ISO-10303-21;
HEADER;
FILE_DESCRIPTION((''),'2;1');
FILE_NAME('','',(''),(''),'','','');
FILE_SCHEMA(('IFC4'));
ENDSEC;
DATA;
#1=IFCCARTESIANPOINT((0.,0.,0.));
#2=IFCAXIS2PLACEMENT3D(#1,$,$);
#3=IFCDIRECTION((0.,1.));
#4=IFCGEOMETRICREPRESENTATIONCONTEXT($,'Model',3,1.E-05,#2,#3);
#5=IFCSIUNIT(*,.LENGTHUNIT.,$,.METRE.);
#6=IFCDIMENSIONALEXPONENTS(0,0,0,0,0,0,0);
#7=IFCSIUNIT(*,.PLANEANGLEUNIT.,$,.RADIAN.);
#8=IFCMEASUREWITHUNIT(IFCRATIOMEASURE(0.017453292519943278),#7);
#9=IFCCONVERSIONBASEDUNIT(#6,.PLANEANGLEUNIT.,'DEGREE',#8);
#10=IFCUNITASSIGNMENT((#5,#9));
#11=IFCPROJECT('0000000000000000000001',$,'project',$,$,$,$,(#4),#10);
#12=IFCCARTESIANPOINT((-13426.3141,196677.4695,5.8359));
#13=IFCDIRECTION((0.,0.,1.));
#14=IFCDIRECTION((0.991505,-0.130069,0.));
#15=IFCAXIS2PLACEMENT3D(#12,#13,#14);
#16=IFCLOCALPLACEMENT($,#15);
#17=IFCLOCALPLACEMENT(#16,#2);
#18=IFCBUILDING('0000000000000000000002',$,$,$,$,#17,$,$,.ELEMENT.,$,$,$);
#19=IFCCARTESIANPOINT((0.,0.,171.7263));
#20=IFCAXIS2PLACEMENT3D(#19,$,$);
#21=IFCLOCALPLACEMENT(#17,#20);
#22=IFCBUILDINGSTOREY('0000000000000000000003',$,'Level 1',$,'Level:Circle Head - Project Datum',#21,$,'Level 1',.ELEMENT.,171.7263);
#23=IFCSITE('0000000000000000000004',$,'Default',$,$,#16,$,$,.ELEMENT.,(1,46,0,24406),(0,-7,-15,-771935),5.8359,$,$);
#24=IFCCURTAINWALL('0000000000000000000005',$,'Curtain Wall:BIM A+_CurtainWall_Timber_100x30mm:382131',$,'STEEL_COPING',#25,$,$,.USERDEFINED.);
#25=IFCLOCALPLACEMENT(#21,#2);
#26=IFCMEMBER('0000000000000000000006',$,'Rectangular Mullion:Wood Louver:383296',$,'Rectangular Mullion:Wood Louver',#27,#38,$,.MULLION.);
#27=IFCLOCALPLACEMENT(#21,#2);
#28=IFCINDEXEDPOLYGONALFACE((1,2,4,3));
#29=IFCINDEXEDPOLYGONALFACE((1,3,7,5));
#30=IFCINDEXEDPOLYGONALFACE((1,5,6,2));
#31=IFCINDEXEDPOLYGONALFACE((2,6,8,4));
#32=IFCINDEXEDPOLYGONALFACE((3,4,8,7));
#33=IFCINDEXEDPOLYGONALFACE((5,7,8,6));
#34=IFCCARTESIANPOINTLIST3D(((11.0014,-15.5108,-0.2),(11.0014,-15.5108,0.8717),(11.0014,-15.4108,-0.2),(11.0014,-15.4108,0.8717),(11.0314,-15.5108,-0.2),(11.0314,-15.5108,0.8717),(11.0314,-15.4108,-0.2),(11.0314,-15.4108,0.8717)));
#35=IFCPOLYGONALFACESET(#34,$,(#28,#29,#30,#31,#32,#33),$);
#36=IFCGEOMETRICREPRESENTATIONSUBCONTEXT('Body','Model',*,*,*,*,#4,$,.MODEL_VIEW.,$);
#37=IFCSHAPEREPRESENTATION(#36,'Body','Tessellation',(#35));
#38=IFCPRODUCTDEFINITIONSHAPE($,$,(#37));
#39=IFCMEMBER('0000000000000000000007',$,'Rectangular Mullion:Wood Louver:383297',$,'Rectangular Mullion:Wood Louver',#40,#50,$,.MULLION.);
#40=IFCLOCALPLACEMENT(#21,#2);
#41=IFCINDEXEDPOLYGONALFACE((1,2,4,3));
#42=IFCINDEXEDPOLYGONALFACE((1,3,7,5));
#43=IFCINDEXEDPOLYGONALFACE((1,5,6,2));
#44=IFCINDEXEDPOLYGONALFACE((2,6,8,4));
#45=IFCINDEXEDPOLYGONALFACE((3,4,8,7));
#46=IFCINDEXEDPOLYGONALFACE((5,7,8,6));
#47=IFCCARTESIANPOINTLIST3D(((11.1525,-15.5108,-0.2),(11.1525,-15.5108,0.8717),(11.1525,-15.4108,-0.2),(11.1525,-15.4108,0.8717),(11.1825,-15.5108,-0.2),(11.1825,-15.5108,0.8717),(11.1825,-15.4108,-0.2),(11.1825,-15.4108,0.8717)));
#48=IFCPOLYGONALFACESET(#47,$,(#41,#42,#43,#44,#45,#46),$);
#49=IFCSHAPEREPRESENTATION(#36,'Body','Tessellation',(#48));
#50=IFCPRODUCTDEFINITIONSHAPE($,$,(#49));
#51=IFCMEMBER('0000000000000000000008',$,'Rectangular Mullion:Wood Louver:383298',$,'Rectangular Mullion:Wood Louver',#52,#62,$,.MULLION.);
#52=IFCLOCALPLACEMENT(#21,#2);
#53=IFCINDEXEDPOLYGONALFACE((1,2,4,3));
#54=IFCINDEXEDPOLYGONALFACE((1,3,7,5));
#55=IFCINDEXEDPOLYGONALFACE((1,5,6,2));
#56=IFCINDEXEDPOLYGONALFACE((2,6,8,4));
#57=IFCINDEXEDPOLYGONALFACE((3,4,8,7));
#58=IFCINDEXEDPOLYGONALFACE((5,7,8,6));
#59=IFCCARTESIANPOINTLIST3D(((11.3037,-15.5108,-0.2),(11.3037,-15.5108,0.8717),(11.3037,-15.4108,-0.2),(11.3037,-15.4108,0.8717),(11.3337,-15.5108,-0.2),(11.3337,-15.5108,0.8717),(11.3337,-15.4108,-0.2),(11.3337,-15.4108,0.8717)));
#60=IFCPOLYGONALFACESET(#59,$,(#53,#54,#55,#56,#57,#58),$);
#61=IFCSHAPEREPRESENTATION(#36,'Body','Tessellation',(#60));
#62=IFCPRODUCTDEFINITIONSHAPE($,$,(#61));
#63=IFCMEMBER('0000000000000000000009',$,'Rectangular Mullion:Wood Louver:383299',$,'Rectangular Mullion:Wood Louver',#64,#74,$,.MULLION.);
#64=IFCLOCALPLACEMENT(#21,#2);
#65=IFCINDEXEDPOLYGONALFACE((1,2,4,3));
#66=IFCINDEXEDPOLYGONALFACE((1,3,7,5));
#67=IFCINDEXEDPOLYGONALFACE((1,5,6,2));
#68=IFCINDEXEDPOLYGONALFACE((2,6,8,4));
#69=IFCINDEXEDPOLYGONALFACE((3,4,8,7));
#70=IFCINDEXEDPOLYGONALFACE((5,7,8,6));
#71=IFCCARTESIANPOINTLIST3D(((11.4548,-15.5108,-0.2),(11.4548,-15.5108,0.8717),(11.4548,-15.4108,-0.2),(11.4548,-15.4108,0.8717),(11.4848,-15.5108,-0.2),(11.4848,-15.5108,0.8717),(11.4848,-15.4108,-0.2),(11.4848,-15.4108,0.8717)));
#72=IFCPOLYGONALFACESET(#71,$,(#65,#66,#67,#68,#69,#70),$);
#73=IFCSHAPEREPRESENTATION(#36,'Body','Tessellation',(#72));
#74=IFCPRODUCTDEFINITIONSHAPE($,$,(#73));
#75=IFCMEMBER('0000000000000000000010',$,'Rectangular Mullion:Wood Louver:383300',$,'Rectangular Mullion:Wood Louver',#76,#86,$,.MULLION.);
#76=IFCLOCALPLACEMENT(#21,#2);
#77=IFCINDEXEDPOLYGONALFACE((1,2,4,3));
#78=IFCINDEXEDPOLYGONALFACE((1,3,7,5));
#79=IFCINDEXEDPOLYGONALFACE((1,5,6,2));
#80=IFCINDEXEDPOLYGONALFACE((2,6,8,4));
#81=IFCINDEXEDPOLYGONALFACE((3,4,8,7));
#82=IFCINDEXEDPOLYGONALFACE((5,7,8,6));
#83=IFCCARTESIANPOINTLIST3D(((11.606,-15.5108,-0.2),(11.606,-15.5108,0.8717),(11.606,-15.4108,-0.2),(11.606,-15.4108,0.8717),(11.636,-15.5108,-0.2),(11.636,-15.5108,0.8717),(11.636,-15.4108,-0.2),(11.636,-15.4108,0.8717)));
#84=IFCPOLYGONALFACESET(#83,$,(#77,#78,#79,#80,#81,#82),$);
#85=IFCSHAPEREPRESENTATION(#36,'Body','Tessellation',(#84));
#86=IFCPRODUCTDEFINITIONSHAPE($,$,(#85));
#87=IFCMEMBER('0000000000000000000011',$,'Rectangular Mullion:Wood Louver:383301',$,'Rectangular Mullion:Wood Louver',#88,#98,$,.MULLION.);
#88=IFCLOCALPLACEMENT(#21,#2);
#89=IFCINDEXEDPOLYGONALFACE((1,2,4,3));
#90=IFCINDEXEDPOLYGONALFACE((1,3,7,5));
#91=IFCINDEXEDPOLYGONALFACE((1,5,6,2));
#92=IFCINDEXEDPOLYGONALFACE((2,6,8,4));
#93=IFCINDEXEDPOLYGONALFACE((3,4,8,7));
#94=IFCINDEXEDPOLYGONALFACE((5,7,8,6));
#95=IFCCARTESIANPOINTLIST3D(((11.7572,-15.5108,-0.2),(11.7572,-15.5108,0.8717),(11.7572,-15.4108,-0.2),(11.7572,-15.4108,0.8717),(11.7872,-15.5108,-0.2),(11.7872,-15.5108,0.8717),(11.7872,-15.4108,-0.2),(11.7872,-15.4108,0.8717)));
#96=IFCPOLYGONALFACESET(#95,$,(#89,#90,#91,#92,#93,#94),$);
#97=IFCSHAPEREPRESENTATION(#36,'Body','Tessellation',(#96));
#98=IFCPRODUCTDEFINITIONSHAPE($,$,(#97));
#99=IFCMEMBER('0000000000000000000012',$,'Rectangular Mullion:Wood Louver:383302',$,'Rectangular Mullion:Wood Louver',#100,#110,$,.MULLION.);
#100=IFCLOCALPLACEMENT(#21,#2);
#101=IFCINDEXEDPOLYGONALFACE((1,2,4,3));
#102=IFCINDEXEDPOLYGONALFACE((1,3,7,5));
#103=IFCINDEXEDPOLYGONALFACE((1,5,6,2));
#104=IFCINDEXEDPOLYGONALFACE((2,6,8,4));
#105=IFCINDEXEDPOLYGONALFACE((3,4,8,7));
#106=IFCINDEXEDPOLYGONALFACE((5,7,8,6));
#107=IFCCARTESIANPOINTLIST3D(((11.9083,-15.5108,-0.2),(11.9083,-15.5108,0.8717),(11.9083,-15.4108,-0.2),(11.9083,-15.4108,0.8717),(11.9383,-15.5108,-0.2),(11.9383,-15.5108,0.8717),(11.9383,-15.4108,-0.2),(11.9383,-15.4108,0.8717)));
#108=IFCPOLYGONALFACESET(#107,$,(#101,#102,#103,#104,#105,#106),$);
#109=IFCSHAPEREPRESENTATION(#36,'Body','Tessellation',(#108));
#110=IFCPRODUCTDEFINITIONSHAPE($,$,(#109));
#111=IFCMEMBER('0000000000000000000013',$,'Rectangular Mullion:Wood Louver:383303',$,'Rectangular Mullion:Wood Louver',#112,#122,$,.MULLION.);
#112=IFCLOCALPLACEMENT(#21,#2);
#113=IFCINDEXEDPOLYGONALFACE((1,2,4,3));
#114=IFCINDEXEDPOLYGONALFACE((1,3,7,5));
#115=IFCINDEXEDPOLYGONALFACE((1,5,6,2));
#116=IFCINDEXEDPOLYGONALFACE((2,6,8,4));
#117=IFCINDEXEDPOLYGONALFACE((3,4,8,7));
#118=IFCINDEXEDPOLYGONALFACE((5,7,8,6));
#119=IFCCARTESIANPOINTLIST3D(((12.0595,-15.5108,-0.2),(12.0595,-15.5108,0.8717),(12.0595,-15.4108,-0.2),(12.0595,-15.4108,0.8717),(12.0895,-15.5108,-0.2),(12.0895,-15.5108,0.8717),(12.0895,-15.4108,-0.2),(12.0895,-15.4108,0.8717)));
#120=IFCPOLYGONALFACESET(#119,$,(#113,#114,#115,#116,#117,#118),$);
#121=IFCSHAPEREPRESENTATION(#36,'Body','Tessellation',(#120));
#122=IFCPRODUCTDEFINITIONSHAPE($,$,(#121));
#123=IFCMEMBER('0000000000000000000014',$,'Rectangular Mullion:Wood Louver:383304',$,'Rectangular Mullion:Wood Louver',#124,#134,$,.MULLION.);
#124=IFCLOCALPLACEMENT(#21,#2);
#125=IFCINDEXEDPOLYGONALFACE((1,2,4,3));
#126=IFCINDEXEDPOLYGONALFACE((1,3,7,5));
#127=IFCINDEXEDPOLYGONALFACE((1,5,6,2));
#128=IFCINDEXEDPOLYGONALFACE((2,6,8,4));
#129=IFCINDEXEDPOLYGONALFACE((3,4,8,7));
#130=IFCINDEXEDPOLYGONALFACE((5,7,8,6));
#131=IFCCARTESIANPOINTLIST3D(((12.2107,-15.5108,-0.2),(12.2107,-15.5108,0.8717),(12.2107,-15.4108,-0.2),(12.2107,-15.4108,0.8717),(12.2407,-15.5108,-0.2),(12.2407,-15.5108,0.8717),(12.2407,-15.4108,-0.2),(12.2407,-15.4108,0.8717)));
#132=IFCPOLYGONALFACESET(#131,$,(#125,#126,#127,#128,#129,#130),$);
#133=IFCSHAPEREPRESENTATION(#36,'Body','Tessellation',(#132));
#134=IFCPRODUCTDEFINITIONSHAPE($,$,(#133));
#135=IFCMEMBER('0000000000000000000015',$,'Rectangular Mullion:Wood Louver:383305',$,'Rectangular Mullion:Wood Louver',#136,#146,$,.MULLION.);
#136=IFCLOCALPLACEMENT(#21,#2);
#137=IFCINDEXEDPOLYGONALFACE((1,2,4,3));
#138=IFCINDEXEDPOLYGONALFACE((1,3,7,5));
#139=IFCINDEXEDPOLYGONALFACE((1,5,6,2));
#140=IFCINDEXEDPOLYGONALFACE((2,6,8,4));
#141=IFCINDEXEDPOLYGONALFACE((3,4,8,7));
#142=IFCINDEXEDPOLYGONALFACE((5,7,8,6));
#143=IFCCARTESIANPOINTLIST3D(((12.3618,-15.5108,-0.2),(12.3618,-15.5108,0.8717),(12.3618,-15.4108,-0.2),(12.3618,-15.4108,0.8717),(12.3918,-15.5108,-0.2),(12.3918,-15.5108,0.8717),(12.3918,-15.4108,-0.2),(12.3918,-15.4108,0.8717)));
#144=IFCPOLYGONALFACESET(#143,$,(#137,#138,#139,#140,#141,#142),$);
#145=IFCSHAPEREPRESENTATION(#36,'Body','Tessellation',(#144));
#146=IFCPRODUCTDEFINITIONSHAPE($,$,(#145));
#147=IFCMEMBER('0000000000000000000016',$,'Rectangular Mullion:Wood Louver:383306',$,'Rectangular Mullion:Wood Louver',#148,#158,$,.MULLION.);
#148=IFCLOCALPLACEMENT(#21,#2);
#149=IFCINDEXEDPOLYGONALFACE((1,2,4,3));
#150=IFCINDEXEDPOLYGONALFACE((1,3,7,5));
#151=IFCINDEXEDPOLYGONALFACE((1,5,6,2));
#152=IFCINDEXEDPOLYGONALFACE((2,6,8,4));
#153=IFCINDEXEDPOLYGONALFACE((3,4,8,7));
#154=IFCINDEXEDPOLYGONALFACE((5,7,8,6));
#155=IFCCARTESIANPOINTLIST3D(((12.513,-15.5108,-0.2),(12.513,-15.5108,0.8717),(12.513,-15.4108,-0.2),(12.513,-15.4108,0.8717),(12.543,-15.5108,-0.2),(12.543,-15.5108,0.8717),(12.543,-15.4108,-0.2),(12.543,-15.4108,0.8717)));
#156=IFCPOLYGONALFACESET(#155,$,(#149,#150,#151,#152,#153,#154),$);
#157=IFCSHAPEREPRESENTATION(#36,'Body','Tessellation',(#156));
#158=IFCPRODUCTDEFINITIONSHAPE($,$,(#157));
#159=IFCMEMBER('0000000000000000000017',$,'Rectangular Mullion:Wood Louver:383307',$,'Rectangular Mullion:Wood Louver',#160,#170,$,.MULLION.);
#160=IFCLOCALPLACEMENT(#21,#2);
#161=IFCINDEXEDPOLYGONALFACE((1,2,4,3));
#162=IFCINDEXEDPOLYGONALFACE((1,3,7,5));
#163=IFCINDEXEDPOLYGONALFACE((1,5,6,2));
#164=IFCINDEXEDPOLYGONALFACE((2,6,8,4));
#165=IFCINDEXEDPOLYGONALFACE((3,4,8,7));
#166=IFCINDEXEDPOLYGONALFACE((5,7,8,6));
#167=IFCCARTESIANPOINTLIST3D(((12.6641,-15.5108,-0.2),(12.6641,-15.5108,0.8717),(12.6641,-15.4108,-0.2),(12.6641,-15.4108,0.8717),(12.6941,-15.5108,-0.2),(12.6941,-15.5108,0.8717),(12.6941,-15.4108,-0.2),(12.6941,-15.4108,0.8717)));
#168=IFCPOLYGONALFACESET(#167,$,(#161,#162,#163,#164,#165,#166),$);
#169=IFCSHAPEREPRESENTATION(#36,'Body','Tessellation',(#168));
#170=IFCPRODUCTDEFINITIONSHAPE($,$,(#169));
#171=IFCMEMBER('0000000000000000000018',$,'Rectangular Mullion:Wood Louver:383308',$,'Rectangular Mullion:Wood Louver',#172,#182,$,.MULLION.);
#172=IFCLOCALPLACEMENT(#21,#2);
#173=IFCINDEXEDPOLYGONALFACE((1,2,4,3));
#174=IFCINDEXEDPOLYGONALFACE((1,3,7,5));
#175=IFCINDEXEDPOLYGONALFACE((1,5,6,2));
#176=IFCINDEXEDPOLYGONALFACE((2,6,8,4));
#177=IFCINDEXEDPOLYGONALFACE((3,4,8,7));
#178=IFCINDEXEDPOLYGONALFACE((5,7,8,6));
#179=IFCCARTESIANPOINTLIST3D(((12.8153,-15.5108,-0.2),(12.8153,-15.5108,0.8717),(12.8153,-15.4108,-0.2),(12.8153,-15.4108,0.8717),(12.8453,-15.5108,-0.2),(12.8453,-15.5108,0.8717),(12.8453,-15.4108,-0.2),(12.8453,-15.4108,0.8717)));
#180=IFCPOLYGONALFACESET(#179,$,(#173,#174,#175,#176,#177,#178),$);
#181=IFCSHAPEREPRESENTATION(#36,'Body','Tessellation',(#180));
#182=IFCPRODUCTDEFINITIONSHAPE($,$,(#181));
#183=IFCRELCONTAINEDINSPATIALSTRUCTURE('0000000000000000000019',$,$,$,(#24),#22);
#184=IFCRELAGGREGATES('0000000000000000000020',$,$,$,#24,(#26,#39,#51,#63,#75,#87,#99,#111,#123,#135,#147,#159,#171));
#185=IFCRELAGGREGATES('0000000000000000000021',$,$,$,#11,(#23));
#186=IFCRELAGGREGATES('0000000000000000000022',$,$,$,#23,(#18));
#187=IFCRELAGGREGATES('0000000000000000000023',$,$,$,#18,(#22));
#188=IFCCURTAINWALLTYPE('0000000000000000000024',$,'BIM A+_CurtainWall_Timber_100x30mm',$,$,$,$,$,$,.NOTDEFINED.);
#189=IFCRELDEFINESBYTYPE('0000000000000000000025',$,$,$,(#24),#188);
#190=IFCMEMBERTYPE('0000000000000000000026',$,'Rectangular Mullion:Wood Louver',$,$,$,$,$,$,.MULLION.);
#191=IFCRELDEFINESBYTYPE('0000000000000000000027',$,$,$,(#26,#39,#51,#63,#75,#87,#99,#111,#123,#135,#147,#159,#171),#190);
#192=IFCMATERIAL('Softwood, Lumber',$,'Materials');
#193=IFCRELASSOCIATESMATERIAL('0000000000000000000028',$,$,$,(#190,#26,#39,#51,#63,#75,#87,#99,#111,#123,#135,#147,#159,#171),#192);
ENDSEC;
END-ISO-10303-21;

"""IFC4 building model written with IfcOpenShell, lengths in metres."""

from ifc_helpers import new_model, entity, si_unit, converted_unit, direction, frame, origin, place, context, subcontext, project, spatial, indexed_curve, outline, extrude, source, transform, mapped, material, type_object, type_shapes, element, aggregate, save


model = new_model("IFC4")

# Units and contexts
model_context = context("Model", 3, precision=1e-05, world=origin(), true_north=direction((0.0, 1.0)))
body_context = subcontext(model_context, "Body", "Model", "MODEL_VIEW")
ifc_project = project(units=[si_unit("LENGTHUNIT", "METRE"), converted_unit("PLANEANGLEUNIT", "DEGREE", entity("IfcRatioMeasure", 0.017453292519943278), si_unit("PLANEANGLEUNIT", "RADIAN"), dimensions=[0, 0, 0, 0, 0, 0, 0])], contexts=[model_context])

# Site, building, storey
site_placement = place(None, frame((-13426.3141, 196677.4695, 5.8359), z_axis=(0.0, 0.0, 1.0), x_axis=(0.991505, -0.130069, 0.0)))
site = spatial("IfcSite", under=ifc_project, at=site_placement, Name="Default", CompositionType="ELEMENT", RefLatitude=(1, 46, 0, 24406), RefLongitude=(0, -7, -15, -771935), RefElevation=5.8359)
building_placement = place(site_placement, origin())
building = spatial("IfcBuilding", under=site, at=building_placement, CompositionType="ELEMENT")
storey_placement = place(building_placement, frame((0.0, 0.0, 171.7263)))
storey = spatial("IfcBuildingStorey", under=building, at=storey_placement, Name="Level 1", ObjectType="Level:Circle Head - Project Datum", LongName="Level 1", CompositionType="ELEMENT", Elevation=171.7263)

# Curtain wall, members
curtain_wall_type = type_object("IfcCurtainWallType", Name="BIM A+_CurtainWall_Timber_100x30mm", PredefinedType="NOTDEFINED")
curtain_wall_placement = place(storey_placement, frame((0.0, 0.0, -171.7263)))
curtain_wall = element("IfcCurtainWall", 1, at=curtain_wall_placement, inside=storey, type_object=curtain_wall_type, Name="Curtain Wall:BIM A+_CurtainWall_Timber_100x30mm:382131", ObjectType="STEEL_COPING", PredefinedType="USERDEFINED")
ifc_material_1 = material(Name="Softwood, Lumber", Category="Materials")
member_type_1 = type_object("IfcMemberType", Name="Rectangular Mullion:Wood Louver", PredefinedType="MULLION", material=ifc_material_1)
shared_shape_1 = source(origin(), body_context, "Body", "SweptSolid", [
    extrude(outline(indexed_curve([(-0.05, -0.015), (0.05, -0.015), (0.05, 0.015), (-0.05, 0.015), (-0.05, -0.015)], self_intersect=False)), frame((0.0, -0.035, -1.0717), z_axis=(0.0, 0.0, 1.0), x_axis=(0.0, -1.0, 0.0)), (0.0, 0.0, 1.0), 1.0717),
])
type_shapes(member_type_1, [shared_shape_1])
member_1_placement = place(curtain_wall_placement, frame((11.0164, -15.4958, 171.5263), z_axis=(0.0, 0.0, -1.0), x_axis=(1.0, 0.0, 0.0)))
member_1 = element("IfcMember", 2, at=member_1_placement, type_object=member_type_1, material=ifc_material_1, Name="Rectangular Mullion:Wood Louver:383296", ObjectType="Rectangular Mullion:Wood Louver", PredefinedType="MULLION", context=body_context, shape_type="MappedRepresentation", body=[
    mapped(shared_shape_1, transform((0.0, 0.0, 0.0), scale=1.0)),
])
member_2_placement = place(curtain_wall_placement, frame((11.1675, -15.4958, 171.5263), z_axis=(0.0, 0.0, -1.0), x_axis=(1.0, 0.0, 0.0)))
member_2 = element("IfcMember", 3, at=member_2_placement, type_object=member_type_1, material=ifc_material_1, Name="Rectangular Mullion:Wood Louver:383297", ObjectType="Rectangular Mullion:Wood Louver", PredefinedType="MULLION", context=body_context, shape_type="MappedRepresentation", body=[
    mapped(shared_shape_1, transform((0.0, 0.0, 0.0), scale=1.0)),
])
member_3_placement = place(curtain_wall_placement, frame((11.3187, -15.4958, 171.5263), z_axis=(0.0, 0.0, -1.0), x_axis=(1.0, 0.0, 0.0)))
member_3 = element("IfcMember", 4, at=member_3_placement, type_object=member_type_1, material=ifc_material_1, Name="Rectangular Mullion:Wood Louver:383298", ObjectType="Rectangular Mullion:Wood Louver", PredefinedType="MULLION", context=body_context, shape_type="MappedRepresentation", body=[
    mapped(shared_shape_1, transform((0.0, 0.0, 0.0), scale=1.0)),
])
member_4_placement = place(curtain_wall_placement, frame((11.4698, -15.4958, 171.5263), z_axis=(0.0, 0.0, -1.0), x_axis=(1.0, 0.0, 0.0)))
member_4 = element("IfcMember", 5, at=member_4_placement, type_object=member_type_1, material=ifc_material_1, Name="Rectangular Mullion:Wood Louver:383299", ObjectType="Rectangular Mullion:Wood Louver", PredefinedType="MULLION", context=body_context, shape_type="MappedRepresentation", body=[
    mapped(shared_shape_1, transform((0.0, 0.0, 0.0), scale=1.0)),
])
member_5_placement = place(curtain_wall_placement, frame((11.621, -15.4958, 171.5263), z_axis=(0.0, 0.0, -1.0), x_axis=(1.0, 0.0, 0.0)))
member_5 = element("IfcMember", 6, at=member_5_placement, type_object=member_type_1, material=ifc_material_1, Name="Rectangular Mullion:Wood Louver:383300", ObjectType="Rectangular Mullion:Wood Louver", PredefinedType="MULLION", context=body_context, shape_type="MappedRepresentation", body=[
    mapped(shared_shape_1, transform((0.0, 0.0, 0.0), scale=1.0)),
])
member_6_placement = place(curtain_wall_placement, frame((11.7722, -15.4958, 171.5263), z_axis=(0.0, 0.0, -1.0), x_axis=(1.0, 0.0, 0.0)))
member_6 = element("IfcMember", 7, at=member_6_placement, type_object=member_type_1, material=ifc_material_1, Name="Rectangular Mullion:Wood Louver:383301", ObjectType="Rectangular Mullion:Wood Louver", PredefinedType="MULLION", context=body_context, shape_type="MappedRepresentation", body=[
    mapped(shared_shape_1, transform((0.0, 0.0, 0.0), scale=1.0)),
])
member_7_placement = place(curtain_wall_placement, frame((11.9233, -15.4958, 171.5263), z_axis=(0.0, 0.0, -1.0), x_axis=(1.0, 0.0, 0.0)))
member_7 = element("IfcMember", 8, at=member_7_placement, type_object=member_type_1, material=ifc_material_1, Name="Rectangular Mullion:Wood Louver:383302", ObjectType="Rectangular Mullion:Wood Louver", PredefinedType="MULLION", context=body_context, shape_type="MappedRepresentation", body=[
    mapped(shared_shape_1, transform((0.0, 0.0, 0.0), scale=1.0)),
])
member_8_placement = place(curtain_wall_placement, frame((12.0745, -15.4958, 171.5263), z_axis=(0.0, 0.0, -1.0), x_axis=(1.0, 0.0, 0.0)))
member_8 = element("IfcMember", 9, at=member_8_placement, type_object=member_type_1, material=ifc_material_1, Name="Rectangular Mullion:Wood Louver:383303", ObjectType="Rectangular Mullion:Wood Louver", PredefinedType="MULLION", context=body_context, shape_type="MappedRepresentation", body=[
    mapped(shared_shape_1, transform((0.0, 0.0, 0.0), scale=1.0)),
])
member_9_placement = place(curtain_wall_placement, frame((12.2257, -15.4958, 171.5263), z_axis=(0.0, 0.0, -1.0), x_axis=(1.0, 0.0, 0.0)))
member_9 = element("IfcMember", 10, at=member_9_placement, type_object=member_type_1, material=ifc_material_1, Name="Rectangular Mullion:Wood Louver:383304", ObjectType="Rectangular Mullion:Wood Louver", PredefinedType="MULLION", context=body_context, shape_type="MappedRepresentation", body=[
    mapped(shared_shape_1, transform((0.0, 0.0, 0.0), scale=1.0)),
])
member_10_placement = place(curtain_wall_placement, frame((12.3768, -15.4958, 171.5263), z_axis=(0.0, 0.0, -1.0), x_axis=(1.0, 0.0, 0.0)))
member_10 = element("IfcMember", 11, at=member_10_placement, type_object=member_type_1, material=ifc_material_1, Name="Rectangular Mullion:Wood Louver:383305", ObjectType="Rectangular Mullion:Wood Louver", PredefinedType="MULLION", context=body_context, shape_type="MappedRepresentation", body=[
    mapped(shared_shape_1, transform((0.0, 0.0, 0.0), scale=1.0)),
])
member_11_placement = place(curtain_wall_placement, frame((12.528, -15.4958, 171.5263), z_axis=(0.0, 0.0, -1.0), x_axis=(1.0, 0.0, 0.0)))
member_11 = element("IfcMember", 12, at=member_11_placement, type_object=member_type_1, material=ifc_material_1, Name="Rectangular Mullion:Wood Louver:383306", ObjectType="Rectangular Mullion:Wood Louver", PredefinedType="MULLION", context=body_context, shape_type="MappedRepresentation", body=[
    mapped(shared_shape_1, transform((0.0, 0.0, 0.0), scale=1.0)),
])
member_12_placement = place(curtain_wall_placement, frame((12.6791, -15.4958, 171.5263), z_axis=(0.0, 0.0, -1.0), x_axis=(1.0, 0.0, 0.0)))
member_12 = element("IfcMember", 13, at=member_12_placement, type_object=member_type_1, material=ifc_material_1, Name="Rectangular Mullion:Wood Louver:383307", ObjectType="Rectangular Mullion:Wood Louver", PredefinedType="MULLION", context=body_context, shape_type="MappedRepresentation", body=[
    mapped(shared_shape_1, transform((0.0, 0.0, 0.0), scale=1.0)),
])
member_13_placement = place(curtain_wall_placement, frame((12.8303, -15.4958, 171.5263), z_axis=(0.0, 0.0, -1.0), x_axis=(1.0, 0.0, 0.0)))
member_13 = element("IfcMember", 14, at=member_13_placement, type_object=member_type_1, material=ifc_material_1, Name="Rectangular Mullion:Wood Louver:383308", ObjectType="Rectangular Mullion:Wood Louver", PredefinedType="MULLION", context=body_context, shape_type="MappedRepresentation", body=[
    mapped(shared_shape_1, transform((0.0, 0.0, 0.0), scale=1.0)),
])
aggregate(curtain_wall, [member_1, member_2, member_3, member_4, member_5, member_6, member_7, member_8, member_9, member_10, member_11, member_12, member_13])

save(model, "model.ifc")
